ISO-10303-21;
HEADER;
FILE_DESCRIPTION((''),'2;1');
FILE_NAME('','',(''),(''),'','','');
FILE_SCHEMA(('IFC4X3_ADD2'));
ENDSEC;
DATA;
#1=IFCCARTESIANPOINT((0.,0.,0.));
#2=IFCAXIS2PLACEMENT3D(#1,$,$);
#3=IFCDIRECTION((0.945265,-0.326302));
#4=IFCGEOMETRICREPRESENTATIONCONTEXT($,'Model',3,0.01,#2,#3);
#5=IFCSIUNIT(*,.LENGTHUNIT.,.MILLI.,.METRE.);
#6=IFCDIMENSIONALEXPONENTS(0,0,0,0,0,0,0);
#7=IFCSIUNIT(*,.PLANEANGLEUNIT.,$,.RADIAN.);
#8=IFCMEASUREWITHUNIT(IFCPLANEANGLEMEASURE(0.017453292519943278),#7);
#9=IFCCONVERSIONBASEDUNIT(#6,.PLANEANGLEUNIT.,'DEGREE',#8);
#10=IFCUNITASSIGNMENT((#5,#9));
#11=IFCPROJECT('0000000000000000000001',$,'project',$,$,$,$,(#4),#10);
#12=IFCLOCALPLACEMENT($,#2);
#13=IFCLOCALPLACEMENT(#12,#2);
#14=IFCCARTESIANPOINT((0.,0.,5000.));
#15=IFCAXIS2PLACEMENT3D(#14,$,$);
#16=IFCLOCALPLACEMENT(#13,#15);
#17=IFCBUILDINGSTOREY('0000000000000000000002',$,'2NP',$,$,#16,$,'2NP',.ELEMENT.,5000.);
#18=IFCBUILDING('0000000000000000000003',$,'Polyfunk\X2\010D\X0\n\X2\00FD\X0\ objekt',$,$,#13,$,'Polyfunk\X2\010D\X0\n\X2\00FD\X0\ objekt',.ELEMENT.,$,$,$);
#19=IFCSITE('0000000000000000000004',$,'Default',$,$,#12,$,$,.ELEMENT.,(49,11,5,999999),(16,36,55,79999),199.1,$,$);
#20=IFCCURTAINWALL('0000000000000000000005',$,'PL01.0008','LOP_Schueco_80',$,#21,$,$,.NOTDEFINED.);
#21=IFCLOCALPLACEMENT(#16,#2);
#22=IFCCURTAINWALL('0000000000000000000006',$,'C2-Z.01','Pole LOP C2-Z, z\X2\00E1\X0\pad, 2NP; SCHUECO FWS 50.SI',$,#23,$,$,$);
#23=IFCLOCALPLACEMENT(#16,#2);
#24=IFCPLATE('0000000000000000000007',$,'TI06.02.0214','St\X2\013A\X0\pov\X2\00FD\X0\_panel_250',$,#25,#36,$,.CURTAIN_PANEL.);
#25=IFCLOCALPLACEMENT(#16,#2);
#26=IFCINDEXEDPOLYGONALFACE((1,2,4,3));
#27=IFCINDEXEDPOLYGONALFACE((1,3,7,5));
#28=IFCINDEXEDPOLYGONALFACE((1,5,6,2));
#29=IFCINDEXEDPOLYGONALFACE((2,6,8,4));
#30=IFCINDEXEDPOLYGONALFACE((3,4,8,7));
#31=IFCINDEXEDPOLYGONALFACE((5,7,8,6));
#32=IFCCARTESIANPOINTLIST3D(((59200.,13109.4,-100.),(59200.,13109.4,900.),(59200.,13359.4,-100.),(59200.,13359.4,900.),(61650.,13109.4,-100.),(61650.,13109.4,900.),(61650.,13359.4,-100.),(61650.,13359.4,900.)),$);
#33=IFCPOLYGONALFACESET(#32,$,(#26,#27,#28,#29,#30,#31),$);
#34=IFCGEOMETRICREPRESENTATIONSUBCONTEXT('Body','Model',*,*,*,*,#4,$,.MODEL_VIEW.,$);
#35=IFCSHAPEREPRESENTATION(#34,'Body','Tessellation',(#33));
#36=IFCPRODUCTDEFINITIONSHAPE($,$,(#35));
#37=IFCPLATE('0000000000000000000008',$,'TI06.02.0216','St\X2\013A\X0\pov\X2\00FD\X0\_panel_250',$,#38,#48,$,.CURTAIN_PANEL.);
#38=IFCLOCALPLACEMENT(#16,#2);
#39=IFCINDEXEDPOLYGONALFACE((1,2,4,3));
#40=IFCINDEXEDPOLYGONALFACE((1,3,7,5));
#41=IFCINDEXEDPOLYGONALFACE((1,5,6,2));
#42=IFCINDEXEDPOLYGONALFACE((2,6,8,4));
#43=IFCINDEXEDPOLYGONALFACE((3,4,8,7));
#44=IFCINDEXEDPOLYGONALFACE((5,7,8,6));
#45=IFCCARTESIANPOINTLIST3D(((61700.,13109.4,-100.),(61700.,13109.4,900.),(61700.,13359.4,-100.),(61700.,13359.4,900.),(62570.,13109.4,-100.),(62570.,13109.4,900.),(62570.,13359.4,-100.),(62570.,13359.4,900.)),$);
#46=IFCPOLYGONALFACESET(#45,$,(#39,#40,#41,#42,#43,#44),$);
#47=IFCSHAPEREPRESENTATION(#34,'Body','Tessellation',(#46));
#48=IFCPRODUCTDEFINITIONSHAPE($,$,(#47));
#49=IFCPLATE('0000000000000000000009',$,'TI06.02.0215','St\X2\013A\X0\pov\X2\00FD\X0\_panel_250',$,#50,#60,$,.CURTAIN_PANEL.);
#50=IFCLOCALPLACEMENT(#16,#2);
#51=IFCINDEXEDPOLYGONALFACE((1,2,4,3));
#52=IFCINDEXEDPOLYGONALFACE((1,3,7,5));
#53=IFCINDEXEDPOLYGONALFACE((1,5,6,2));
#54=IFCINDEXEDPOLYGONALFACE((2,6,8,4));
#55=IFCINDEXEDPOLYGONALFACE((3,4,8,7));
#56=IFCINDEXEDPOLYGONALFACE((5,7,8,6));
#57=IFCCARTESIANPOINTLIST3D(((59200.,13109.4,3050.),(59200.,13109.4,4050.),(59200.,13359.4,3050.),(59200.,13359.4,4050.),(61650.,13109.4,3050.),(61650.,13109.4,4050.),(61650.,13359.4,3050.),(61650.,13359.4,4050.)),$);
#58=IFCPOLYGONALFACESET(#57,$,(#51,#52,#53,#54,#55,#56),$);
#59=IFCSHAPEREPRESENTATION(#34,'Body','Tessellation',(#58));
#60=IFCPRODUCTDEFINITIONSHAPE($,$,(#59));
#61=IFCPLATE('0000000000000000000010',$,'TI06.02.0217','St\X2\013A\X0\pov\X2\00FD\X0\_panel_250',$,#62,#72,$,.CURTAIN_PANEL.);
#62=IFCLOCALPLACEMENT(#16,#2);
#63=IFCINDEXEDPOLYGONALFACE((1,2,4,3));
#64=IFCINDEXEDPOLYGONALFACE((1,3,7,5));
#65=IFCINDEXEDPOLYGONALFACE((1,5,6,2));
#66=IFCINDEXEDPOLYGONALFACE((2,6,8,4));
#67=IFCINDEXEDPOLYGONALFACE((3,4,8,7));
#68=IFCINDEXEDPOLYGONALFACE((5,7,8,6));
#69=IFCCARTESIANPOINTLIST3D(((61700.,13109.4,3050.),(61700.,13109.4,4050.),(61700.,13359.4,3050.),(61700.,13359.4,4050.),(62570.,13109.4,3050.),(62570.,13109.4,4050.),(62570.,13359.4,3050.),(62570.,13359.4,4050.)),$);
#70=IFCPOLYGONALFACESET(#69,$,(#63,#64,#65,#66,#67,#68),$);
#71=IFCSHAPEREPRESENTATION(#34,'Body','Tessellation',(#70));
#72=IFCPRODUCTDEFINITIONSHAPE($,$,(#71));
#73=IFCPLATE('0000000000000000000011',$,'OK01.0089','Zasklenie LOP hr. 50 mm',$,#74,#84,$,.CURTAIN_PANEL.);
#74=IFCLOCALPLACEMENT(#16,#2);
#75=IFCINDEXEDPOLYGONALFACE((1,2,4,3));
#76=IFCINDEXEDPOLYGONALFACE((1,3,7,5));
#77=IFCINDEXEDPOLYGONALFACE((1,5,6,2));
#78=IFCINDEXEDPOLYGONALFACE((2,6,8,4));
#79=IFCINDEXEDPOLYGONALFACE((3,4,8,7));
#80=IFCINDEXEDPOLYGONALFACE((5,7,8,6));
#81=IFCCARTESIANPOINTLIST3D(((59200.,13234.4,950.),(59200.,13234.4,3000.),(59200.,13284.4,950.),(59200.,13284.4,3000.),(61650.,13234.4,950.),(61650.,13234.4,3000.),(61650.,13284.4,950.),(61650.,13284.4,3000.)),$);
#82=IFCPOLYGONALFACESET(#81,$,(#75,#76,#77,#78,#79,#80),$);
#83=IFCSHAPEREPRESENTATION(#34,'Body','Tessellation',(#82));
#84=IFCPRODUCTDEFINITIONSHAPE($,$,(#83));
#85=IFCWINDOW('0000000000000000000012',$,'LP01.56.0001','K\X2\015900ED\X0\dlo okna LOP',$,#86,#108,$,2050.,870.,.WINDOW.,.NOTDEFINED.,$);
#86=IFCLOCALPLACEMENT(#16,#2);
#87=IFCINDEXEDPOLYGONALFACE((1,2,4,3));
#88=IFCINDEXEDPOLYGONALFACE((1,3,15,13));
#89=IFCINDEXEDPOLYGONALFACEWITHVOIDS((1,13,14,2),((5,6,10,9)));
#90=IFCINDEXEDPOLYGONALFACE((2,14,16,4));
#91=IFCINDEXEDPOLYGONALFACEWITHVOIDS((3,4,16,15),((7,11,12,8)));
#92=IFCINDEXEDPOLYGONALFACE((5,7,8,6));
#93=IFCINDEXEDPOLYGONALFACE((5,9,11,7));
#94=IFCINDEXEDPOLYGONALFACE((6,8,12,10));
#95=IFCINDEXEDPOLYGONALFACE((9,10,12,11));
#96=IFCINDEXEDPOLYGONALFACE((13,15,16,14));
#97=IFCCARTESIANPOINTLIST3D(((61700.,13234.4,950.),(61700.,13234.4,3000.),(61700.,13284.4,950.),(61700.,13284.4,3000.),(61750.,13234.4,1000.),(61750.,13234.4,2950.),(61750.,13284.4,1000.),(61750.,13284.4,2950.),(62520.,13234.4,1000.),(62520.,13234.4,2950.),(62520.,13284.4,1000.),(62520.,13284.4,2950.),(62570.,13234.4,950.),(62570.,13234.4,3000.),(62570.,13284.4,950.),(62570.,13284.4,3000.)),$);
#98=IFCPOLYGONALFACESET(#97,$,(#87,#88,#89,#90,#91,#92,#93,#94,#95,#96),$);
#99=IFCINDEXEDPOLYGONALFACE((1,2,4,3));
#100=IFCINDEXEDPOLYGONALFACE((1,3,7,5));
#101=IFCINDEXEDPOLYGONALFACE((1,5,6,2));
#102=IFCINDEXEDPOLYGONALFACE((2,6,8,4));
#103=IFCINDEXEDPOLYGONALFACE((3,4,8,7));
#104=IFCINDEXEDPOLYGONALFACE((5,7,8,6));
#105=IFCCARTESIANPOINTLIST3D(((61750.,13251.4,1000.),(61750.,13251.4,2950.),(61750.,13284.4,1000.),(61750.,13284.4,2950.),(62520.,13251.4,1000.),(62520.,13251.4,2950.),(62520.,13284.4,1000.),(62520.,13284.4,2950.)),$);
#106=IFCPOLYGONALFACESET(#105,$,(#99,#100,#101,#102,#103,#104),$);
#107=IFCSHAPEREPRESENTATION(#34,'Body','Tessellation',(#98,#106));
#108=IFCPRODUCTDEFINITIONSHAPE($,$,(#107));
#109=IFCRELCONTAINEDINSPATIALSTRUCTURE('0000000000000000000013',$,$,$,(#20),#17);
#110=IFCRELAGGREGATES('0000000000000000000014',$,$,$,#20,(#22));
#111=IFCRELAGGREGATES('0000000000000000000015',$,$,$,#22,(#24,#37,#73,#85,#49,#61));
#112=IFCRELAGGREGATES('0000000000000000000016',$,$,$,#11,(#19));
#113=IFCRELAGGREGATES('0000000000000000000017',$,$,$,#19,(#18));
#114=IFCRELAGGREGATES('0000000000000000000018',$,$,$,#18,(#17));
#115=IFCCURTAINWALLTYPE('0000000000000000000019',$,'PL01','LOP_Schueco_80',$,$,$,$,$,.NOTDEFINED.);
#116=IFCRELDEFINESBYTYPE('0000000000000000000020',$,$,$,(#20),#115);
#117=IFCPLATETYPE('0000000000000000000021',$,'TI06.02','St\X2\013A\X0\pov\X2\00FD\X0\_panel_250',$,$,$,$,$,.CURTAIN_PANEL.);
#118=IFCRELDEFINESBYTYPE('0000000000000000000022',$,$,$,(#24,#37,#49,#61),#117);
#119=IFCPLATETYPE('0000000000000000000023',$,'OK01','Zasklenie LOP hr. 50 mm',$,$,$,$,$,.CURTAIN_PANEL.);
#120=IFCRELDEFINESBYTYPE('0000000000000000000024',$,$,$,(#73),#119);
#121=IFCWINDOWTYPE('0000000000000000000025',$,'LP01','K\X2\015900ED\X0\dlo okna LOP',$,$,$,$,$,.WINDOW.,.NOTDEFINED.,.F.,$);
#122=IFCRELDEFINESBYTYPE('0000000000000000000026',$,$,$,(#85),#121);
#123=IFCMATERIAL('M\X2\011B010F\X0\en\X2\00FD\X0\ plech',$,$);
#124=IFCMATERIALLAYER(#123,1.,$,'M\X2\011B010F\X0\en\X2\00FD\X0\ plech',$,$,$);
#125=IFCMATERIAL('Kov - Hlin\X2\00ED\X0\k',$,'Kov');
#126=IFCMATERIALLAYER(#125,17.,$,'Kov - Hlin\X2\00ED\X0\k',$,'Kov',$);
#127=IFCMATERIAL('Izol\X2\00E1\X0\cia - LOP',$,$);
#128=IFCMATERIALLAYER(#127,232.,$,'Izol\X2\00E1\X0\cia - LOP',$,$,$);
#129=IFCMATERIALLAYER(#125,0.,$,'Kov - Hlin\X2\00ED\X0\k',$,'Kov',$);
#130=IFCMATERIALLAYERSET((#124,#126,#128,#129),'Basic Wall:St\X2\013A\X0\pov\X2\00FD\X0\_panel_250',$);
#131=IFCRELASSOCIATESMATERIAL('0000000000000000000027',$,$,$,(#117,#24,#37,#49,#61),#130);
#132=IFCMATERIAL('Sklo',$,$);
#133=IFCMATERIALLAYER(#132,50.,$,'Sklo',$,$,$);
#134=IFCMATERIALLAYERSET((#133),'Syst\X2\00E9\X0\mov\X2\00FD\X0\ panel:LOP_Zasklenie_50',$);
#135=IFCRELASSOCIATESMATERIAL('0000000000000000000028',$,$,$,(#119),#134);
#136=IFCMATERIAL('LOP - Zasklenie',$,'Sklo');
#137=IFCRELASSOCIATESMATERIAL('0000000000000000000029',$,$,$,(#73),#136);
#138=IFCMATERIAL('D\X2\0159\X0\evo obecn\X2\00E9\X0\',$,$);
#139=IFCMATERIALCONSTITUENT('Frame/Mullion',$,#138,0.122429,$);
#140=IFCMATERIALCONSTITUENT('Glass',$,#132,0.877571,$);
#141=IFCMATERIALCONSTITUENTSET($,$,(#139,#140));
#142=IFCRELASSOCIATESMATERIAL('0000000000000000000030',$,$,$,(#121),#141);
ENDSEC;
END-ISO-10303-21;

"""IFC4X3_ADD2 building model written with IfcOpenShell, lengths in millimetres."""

from ifc_helpers import new_model, entity, si_unit, converted_unit, direction, frame, frame_2d, origin, origin_2d_with_axis, place, context, subcontext, project, spatial, polyline, rectangle, outline, extrude, source, transform, mapped, material, layer, layer_set, layer_usage, constituent, constituent_set, type_object, type_shapes, element, aggregate, save


model = new_model("IFC4X3_ADD2")

# Units and contexts
model_context = context("Model", 3, precision=0.01, world=origin(), true_north=direction((0.945265, -0.326302)))
body_context = subcontext(model_context, "Body", "Model", "MODEL_VIEW")
ifc_project = project(units=[si_unit("LENGTHUNIT", "METRE", prefix="MILLI"), converted_unit("PLANEANGLEUNIT", "DEGREE", entity("IfcPlaneAngleMeasure", 0.017453292519943278), si_unit("PLANEANGLEUNIT", "RADIAN"), dimensions=[0, 0, 0, 0, 0, 0, 0])], contexts=[model_context])

# Site, building, storey
site_placement = place(None, origin())
site = spatial("IfcSite", under=ifc_project, at=site_placement, Name="Default", CompositionType="ELEMENT", RefLatitude=(49, 11, 5, 999999), RefLongitude=(16, 36, 55, 79999), RefElevation=199.1)
building_placement = place(site_placement, origin())
building = spatial("IfcBuilding", under=site, at=building_placement, Name="Polyfunkčný objekt", LongName="Polyfunkčný objekt", CompositionType="ELEMENT")
storey_placement = place(building_placement, frame((0.0, 0.0, 5000.0)))
storey = spatial("IfcBuildingStorey", under=building, at=storey_placement, Name="2NP", LongName="2NP", CompositionType="ELEMENT", Elevation=5000.0)

# Curtain walls, plates, window
curtain_wall_type = type_object("IfcCurtainWallType", Name="PL01", Description="LOP_Schueco_80", PredefinedType="NOTDEFINED")
curtain_wall_1_placement = place(storey_placement, frame((0.0, 0.0, -5000.0)))
curtain_wall_1 = element("IfcCurtainWall", 1, at=curtain_wall_1_placement, inside=storey, type_object=curtain_wall_type, Name="PL01.0008", Description="LOP_Schueco_80", PredefinedType="NOTDEFINED")
curtain_wall_2 = element("IfcCurtainWall", 2, Name="C2-Z.01", Description="Pole LOP C2-Z, západ, 2NP; SCHUECO FWS 50.SI")
aggregate(curtain_wall_1, [curtain_wall_2])
ifc_material_1 = material(Name="Měďený plech")
ifc_layer_1 = layer(ifc_material_1, 1.0, Name="Měďený plech")
ifc_material_2 = material(Name="Kov - Hliník", Category="Kov")
ifc_layer_2 = layer(ifc_material_2, 17.0, Name="Kov - Hliník", Category="Kov")
ifc_material_3 = material(Name="Izolácia - LOP")
ifc_layer_3 = layer(ifc_material_3, 232.0, Name="Izolácia - LOP")
ifc_layer_4 = layer(ifc_material_2, 0.0, Name="Kov - Hliník", Category="Kov")
ifc_layer_set_1 = layer_set([ifc_layer_1, ifc_layer_2, ifc_layer_3, ifc_layer_4], Name="Basic Wall:Stĺpový_panel_250")
ifc_layer_usage_1 = layer_usage(ifc_layer_set_1, "AXIS2", "NEGATIVE", 125.0)
plate_type_1 = type_object("IfcPlateType", Name="TI06.02", Description="Stĺpový_panel_250", PredefinedType="CURTAIN_PANEL", material=ifc_layer_set_1)
plate_1_placement = place(storey_placement, frame((59200.0, 13234.4, -100.0)))
plate_1 = element("IfcPlate", 3, at=plate_1_placement, type_object=plate_type_1, material=ifc_layer_usage_1, Name="TI06.02.0214", Description="Stĺpový_panel_250", PredefinedType="CURTAIN_PANEL", context=body_context, shape_type="SweptSolid", body=[
    extrude(rectangle(XDim=250.0, YDim=2450.0, at=frame_2d((0.0, 0.0), x_axis=(1.0, 0.0))), frame((1225.0, 0.0, 0.0), z_axis=(0.0, 0.0, 1.0), x_axis=(0.0, 1.0, 0.0)), (0.0, 0.0, 1.0), 1000.0),
])
ifc_layer_usage_2 = layer_usage(ifc_layer_set_1, "AXIS2", "NEGATIVE", 125.0)
plate_2_placement = place(storey_placement, frame((61700.0, 13234.4, -100.0)))
plate_2 = element("IfcPlate", 4, at=plate_2_placement, type_object=plate_type_1, material=ifc_layer_usage_2, Name="TI06.02.0216", Description="Stĺpový_panel_250", PredefinedType="CURTAIN_PANEL", context=body_context, shape_type="SweptSolid", body=[
    extrude(rectangle(XDim=250.0, YDim=870.0, at=frame_2d((0.0, 0.0), x_axis=(1.0, 0.0))), frame((435.0, 0.0, 0.0), z_axis=(0.0, 0.0, 1.0), x_axis=(0.0, 1.0, 0.0)), (0.0, 0.0, 1.0), 1000.0),
])
ifc_layer_usage_3 = layer_usage(ifc_layer_set_1, "AXIS2", "NEGATIVE", 125.0)
plate_3_placement = place(storey_placement, frame((59200.0, 13234.4, 3050.0)))
plate_3 = element("IfcPlate", 5, at=plate_3_placement, type_object=plate_type_1, material=ifc_layer_usage_3, Name="TI06.02.0215", Description="Stĺpový_panel_250", PredefinedType="CURTAIN_PANEL", context=body_context, shape_type="SweptSolid", body=[
    extrude(rectangle(XDim=250.0, YDim=2450.0, at=frame_2d((0.0, 0.0), x_axis=(1.0, 0.0))), frame((1225.0, 0.0, 0.0), z_axis=(0.0, 0.0, 1.0), x_axis=(0.0, 1.0, 0.0)), (0.0, 0.0, 1.0), 1000.0),
])
ifc_layer_usage_4 = layer_usage(ifc_layer_set_1, "AXIS2", "NEGATIVE", 125.0)
plate_4_placement = place(storey_placement, frame((61700.0, 13234.4, 3050.0)))
plate_4 = element("IfcPlate", 6, at=plate_4_placement, type_object=plate_type_1, material=ifc_layer_usage_4, Name="TI06.02.0217", Description="Stĺpový_panel_250", PredefinedType="CURTAIN_PANEL", context=body_context, shape_type="SweptSolid", body=[
    extrude(rectangle(XDim=250.0, YDim=870.0, at=frame_2d((0.0, 0.0), x_axis=(1.0, 0.0))), frame((435.0, 0.0, 0.0), z_axis=(0.0, 0.0, 1.0), x_axis=(0.0, 1.0, 0.0)), (0.0, 0.0, 1.0), 1000.0),
])
ifc_material_4 = material(Name="LOP - Zasklenie", Category="Sklo")
ifc_material_5 = material(Name="Sklo")
ifc_layer_5 = layer(ifc_material_5, 50.0, Name="Sklo")
ifc_layer_set_2 = layer_set([ifc_layer_5], Name="Systémový panel:LOP_Zasklenie_50")
plate_type_2 = type_object("IfcPlateType", Name="OK01", Description="Zasklenie LOP hr. 50 mm", PredefinedType="CURTAIN_PANEL", material=ifc_layer_set_2)
shared_shape_1 = source(origin(), body_context, "Body", "SweptSolid", [
    extrude(rectangle(XDim=50.0, YDim=2450.0, at=origin_2d_with_axis()), frame((0.0, 25.0, 0.0), z_axis=(0.0, 0.0, 1.0), x_axis=(0.0, 1.0, 0.0)), (0.0, 0.0, 1.0), 2050.0),
])
type_shapes(plate_type_2, [shared_shape_1])
plate_5_placement = place(curtain_wall_1_placement, frame((60425.0, 13234.4, 5950.0)))
plate_5 = element("IfcPlate", 7, at=plate_5_placement, type_object=plate_type_2, material=ifc_material_4, Name="OK01.0089", Description="Zasklenie LOP hr. 50 mm", PredefinedType="CURTAIN_PANEL", context=body_context, shape_type="MappedRepresentation", body=[
    mapped(shared_shape_1, transform((0.0, 0.0, 0.0), scale=1.0)),
])
ifc_material_6 = material(Name="Dřevo obecné")
ifc_constituent_1 = constituent(ifc_material_6, Name="Frame/Mullion", fraction=0.122429)
ifc_constituent_2 = constituent(ifc_material_5, Name="Glass", fraction=0.877571)
ifc_constituent_set = constituent_set(constituents=[ifc_constituent_1, ifc_constituent_2])
window_type = type_object("IfcWindowType", Name="LP01", Description="Křídlo okna LOP", ParameterTakesPrecedence=False, PartitioningType="NOTDEFINED", PredefinedType="WINDOW", material=ifc_constituent_set)
shared_shape_2 = source(origin(), body_context, "Body", "SweptSolid", [
    extrude(outline(polyline([(-1025.0, -435.0), (1025.0, -435.0), (1025.0, 435.0), (-1025.0, 435.0), (-1025.0, -435.0)]), holes=[polyline([(-975.0, -385.0), (-975.0, 385.0), (975.0, 385.0), (975.0, -385.0), (-975.0, -385.0)])]), frame((0.0, 0.0, 1025.0), z_axis=(0.0, 1.0, 0.0), x_axis=(0.0, 0.0, -1.0)), (0.0, 0.0, 1.0), 50.0),
    extrude(rectangle(XDim=33.0, YDim=770.0, at=origin_2d_with_axis()), frame((0.0, 33.5, 50.0), z_axis=(0.0, 0.0, 1.0), x_axis=(0.0, -1.0, 0.0)), (0.0, 0.0, 1.0), 1950.0),
])
type_shapes(window_type, [shared_shape_2])
window_placement = place(curtain_wall_1_placement, frame((62135.0, 13234.4, 5950.0)))
window = element("IfcWindow", 8, at=window_placement, type_object=window_type, Name="LP01.56.0001", Description="Křídlo okna LOP", OverallHeight=2050.0, OverallWidth=870.0, PartitioningType="NOTDEFINED", PredefinedType="WINDOW", context=body_context, shape_type="MappedRepresentation", body=[
    mapped(shared_shape_2, transform((0.0, 0.0, 0.0), scale=1.0)),
])
aggregate(curtain_wall_2, [plate_1, plate_2, plate_5, window, plate_3, plate_4])

save(model, "model.ifc")
